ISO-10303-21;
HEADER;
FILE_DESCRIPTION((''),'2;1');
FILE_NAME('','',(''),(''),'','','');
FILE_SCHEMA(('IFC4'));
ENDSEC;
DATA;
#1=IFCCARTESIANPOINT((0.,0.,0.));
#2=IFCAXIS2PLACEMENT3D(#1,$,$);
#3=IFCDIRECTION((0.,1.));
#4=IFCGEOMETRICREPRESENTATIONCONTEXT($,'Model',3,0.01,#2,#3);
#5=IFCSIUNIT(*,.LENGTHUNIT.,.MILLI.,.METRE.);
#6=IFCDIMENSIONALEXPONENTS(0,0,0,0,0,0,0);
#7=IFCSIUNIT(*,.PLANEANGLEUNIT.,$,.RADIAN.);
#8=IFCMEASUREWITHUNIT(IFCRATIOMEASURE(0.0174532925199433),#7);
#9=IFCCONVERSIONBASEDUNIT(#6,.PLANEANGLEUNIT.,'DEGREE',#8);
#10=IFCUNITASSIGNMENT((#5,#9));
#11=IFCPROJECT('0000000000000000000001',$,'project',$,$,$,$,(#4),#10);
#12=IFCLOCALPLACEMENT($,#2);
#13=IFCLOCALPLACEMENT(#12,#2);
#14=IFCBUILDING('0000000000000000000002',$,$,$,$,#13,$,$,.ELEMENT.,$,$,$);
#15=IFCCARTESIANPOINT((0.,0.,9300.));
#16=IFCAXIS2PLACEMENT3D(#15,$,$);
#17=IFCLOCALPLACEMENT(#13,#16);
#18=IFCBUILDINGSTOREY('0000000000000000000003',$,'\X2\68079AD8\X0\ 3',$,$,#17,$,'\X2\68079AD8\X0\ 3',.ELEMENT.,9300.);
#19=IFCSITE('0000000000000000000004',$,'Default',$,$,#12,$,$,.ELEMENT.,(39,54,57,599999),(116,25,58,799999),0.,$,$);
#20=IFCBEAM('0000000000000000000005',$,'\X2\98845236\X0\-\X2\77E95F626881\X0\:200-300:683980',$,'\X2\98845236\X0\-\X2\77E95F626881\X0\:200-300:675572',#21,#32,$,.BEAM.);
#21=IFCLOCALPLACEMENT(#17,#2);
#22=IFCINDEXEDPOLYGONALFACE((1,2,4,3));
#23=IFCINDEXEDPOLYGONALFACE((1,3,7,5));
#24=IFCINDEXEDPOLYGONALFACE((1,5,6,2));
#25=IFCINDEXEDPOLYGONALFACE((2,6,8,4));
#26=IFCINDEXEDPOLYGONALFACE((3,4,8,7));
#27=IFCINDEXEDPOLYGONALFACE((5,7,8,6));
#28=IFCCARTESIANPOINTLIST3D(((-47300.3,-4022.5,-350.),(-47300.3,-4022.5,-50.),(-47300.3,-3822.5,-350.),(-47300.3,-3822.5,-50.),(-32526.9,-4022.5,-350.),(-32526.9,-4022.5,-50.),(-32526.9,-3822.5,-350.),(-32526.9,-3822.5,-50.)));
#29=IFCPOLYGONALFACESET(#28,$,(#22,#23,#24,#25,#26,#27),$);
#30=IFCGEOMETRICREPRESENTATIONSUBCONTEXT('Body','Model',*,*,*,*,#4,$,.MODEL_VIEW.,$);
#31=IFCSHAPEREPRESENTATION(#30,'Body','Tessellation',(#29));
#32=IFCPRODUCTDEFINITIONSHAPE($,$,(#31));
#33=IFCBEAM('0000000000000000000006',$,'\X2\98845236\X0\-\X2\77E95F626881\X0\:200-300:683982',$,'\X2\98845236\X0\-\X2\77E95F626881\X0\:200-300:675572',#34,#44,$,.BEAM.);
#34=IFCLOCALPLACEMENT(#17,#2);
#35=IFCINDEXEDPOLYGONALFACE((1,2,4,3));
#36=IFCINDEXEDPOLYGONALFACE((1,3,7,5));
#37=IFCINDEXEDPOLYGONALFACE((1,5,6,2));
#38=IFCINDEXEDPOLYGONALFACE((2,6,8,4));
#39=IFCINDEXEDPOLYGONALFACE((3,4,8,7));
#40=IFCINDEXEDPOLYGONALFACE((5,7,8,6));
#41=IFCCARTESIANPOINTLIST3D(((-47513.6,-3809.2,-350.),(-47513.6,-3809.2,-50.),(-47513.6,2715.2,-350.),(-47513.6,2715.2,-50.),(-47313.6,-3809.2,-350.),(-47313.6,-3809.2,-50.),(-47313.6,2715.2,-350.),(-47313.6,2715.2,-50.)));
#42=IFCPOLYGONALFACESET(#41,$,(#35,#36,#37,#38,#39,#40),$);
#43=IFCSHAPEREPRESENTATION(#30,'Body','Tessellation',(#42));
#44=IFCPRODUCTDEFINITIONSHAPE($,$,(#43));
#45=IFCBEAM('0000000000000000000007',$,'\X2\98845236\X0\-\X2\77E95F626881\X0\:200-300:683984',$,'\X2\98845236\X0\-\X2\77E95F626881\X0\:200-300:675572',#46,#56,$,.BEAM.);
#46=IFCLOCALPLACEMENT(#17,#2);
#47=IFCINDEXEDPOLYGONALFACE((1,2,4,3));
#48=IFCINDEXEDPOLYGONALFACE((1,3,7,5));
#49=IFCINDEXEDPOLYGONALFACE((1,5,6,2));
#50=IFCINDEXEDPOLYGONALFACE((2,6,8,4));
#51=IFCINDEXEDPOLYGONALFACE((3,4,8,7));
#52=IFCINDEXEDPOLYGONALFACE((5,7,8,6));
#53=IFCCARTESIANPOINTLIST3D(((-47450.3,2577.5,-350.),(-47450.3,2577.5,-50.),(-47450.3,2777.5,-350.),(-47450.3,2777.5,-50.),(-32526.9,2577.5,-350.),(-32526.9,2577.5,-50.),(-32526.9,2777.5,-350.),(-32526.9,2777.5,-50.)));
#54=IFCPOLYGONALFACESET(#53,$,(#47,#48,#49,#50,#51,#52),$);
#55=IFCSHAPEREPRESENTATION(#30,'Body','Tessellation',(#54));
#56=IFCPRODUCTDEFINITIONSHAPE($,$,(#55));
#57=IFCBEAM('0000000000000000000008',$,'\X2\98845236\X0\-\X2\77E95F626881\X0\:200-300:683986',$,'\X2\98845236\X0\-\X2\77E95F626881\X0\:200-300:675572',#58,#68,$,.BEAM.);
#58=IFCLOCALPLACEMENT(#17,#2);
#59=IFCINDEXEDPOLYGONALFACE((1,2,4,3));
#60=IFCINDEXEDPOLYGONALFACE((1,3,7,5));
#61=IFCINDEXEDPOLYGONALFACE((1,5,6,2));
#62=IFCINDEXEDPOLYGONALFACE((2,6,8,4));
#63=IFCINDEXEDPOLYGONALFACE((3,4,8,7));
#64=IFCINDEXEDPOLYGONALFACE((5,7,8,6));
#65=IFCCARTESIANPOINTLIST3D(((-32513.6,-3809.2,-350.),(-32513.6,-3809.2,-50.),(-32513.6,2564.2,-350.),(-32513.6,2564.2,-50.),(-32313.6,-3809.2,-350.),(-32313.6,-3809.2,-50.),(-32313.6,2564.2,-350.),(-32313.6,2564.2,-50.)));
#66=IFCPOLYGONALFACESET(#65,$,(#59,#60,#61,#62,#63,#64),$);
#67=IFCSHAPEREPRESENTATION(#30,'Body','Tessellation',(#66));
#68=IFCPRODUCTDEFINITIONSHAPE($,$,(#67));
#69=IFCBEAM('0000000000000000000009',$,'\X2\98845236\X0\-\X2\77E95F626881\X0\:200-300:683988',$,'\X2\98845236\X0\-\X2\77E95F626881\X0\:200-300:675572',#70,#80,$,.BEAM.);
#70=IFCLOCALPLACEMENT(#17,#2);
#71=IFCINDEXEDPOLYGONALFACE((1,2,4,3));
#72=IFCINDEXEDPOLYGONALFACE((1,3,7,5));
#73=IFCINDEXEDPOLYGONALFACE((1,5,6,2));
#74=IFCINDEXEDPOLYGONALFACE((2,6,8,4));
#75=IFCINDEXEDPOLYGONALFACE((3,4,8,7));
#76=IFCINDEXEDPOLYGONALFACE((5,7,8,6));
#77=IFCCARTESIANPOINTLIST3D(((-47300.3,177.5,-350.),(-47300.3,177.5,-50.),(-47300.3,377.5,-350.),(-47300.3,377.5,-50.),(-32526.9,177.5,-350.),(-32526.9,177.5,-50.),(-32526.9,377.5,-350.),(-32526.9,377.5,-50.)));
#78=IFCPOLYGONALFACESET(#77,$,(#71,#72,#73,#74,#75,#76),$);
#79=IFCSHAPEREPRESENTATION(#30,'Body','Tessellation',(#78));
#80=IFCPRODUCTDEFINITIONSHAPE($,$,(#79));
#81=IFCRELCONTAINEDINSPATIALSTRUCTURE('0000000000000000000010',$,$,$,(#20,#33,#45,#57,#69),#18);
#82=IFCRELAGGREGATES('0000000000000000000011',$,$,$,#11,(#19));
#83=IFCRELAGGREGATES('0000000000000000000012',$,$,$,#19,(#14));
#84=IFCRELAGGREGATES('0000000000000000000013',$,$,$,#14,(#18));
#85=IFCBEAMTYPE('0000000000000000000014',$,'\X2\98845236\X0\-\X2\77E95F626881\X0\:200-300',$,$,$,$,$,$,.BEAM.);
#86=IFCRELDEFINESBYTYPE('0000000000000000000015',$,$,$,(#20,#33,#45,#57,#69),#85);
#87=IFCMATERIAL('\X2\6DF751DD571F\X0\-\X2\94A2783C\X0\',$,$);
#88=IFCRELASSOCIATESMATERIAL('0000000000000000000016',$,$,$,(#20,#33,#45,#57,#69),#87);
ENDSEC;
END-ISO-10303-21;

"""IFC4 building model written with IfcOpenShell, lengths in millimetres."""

from ifc_helpers import new_model, entity, si_unit, converted_unit, direction, frame, frame_2d, origin, place, context, subcontext, project, spatial, rectangle, extrude, material, type_object, element, save


model = new_model("IFC4")

# Units and contexts
model_context = context("Model", 3, precision=0.01, world=origin(), true_north=direction((0.0, 1.0)))
body_context = subcontext(model_context, "Body", "Model", "MODEL_VIEW")
ifc_project = project(units=[si_unit("LENGTHUNIT", "METRE", prefix="MILLI"), converted_unit("PLANEANGLEUNIT", "DEGREE", entity("IfcRatioMeasure", 0.0174532925199433), si_unit("PLANEANGLEUNIT", "RADIAN"), dimensions=[0, 0, 0, 0, 0, 0, 0])], contexts=[model_context])

# Site, building, storey
site_placement = place(None, origin())
site = spatial("IfcSite", under=ifc_project, at=site_placement, Name="Default", CompositionType="ELEMENT", RefLatitude=(39, 54, 57, 599999), RefLongitude=(116, 25, 58, 799999), RefElevation=0.0)
building_placement = place(site_placement, origin())
building = spatial("IfcBuilding", under=site, at=building_placement, CompositionType="ELEMENT")
storey_placement = place(building_placement, frame((0.0, 0.0, 9300.0)))
storey = spatial("IfcBuildingStorey", under=building, at=storey_placement, Name="标高 3", LongName="标高 3", CompositionType="ELEMENT", Elevation=9300.0)

# Beams
ifc_material_1 = material(Name="混凝土-钢砼")
beam_type = type_object("IfcBeamType", Name="预制-矩形梁:200-300", PredefinedType="BEAM")
beam_1_placement = place(storey_placement, frame((-47413.6, -3922.5, -50.0)))
element("IfcBeam", 1, at=beam_1_placement, inside=storey, type_object=beam_type, material=ifc_material_1, Name="预制-矩形梁:200-300:683980", ObjectType="预制-矩形梁:200-300:675572", PredefinedType="BEAM", context=body_context, shape_type="SweptSolid", body=[
    extrude(rectangle(XDim=300.0, YDim=200.0, at=frame_2d((0.0, 0.0), x_axis=(1.0, 0.0))), frame((113.3, 0.0, -150.0), z_axis=(1.0, 0.0, 0.0), x_axis=(0.0, 0.0, -1.0)), (0.0, 0.0, 1.0), 14773.4),
])
beam_2_placement = place(storey_placement, frame((-47413.6, -3922.5, -50.0), z_axis=(0.0, 0.0, 1.0), x_axis=(0.0, 1.0, 0.0)))
element("IfcBeam", 2, at=beam_2_placement, inside=storey, type_object=beam_type, material=ifc_material_1, Name="预制-矩形梁:200-300:683982", ObjectType="预制-矩形梁:200-300:675572", PredefinedType="BEAM", context=body_context, shape_type="SweptSolid", body=[
    extrude(rectangle(XDim=300.0, YDim=200.0, at=frame_2d((0.0, 0.0), x_axis=(1.0, 0.0))), frame((113.3, 0.0, -150.0), z_axis=(1.0, 0.0, 0.0), x_axis=(0.0, 0.0, -1.0)), (0.0, 0.0, 1.0), 6524.4),
])
beam_3_placement = place(storey_placement, frame((-47413.6, 2677.5, -50.0)))
element("IfcBeam", 3, at=beam_3_placement, inside=storey, type_object=beam_type, material=ifc_material_1, Name="预制-矩形梁:200-300:683984", ObjectType="预制-矩形梁:200-300:675572", PredefinedType="BEAM", context=body_context, shape_type="SweptSolid", body=[
    extrude(rectangle(XDim=300.0, YDim=200.0, at=frame_2d((0.0, 0.0), x_axis=(1.0, 0.0))), frame((-36.7, 0.0, -150.0), z_axis=(1.0, 0.0, 0.0), x_axis=(0.0, 0.0, -1.0)), (0.0, 0.0, 1.0), 14923.4),
])
beam_4_placement = place(storey_placement, frame((-32413.6, 2677.5, -50.0), z_axis=(0.0, 0.0, 1.0), x_axis=(0.0, -1.0, 0.0)))
element("IfcBeam", 4, at=beam_4_placement, inside=storey, type_object=beam_type, material=ifc_material_1, Name="预制-矩形梁:200-300:683986", ObjectType="预制-矩形梁:200-300:675572", PredefinedType="BEAM", context=body_context, shape_type="SweptSolid", body=[
    extrude(rectangle(XDim=300.0, YDim=200.0, at=frame_2d((0.0, 0.0), x_axis=(1.0, 0.0))), frame((113.3, 0.0, -150.0), z_axis=(1.0, 0.0, 0.0), x_axis=(0.0, 0.0, -1.0)), (0.0, 0.0, 1.0), 6373.4),
])
beam_5_placement = place(storey_placement, frame((-32413.6, 277.5, -50.0), z_axis=(0.0, 0.0, 1.0), x_axis=(-1.0, 0.0, 0.0)))
element("IfcBeam", 5, at=beam_5_placement, inside=storey, type_object=beam_type, material=ifc_material_1, Name="预制-矩形梁:200-300:683988", ObjectType="预制-矩形梁:200-300:675572", PredefinedType="BEAM", context=body_context, shape_type="SweptSolid", body=[
    extrude(rectangle(XDim=300.0, YDim=200.0, at=frame_2d((0.0, 0.0), x_axis=(1.0, 0.0))), frame((113.3, 0.0, -150.0), z_axis=(1.0, 0.0, 0.0), x_axis=(0.0, 0.0, -1.0)), (0.0, 0.0, 1.0), 14773.4),
])

save(model, "model.ifc")
